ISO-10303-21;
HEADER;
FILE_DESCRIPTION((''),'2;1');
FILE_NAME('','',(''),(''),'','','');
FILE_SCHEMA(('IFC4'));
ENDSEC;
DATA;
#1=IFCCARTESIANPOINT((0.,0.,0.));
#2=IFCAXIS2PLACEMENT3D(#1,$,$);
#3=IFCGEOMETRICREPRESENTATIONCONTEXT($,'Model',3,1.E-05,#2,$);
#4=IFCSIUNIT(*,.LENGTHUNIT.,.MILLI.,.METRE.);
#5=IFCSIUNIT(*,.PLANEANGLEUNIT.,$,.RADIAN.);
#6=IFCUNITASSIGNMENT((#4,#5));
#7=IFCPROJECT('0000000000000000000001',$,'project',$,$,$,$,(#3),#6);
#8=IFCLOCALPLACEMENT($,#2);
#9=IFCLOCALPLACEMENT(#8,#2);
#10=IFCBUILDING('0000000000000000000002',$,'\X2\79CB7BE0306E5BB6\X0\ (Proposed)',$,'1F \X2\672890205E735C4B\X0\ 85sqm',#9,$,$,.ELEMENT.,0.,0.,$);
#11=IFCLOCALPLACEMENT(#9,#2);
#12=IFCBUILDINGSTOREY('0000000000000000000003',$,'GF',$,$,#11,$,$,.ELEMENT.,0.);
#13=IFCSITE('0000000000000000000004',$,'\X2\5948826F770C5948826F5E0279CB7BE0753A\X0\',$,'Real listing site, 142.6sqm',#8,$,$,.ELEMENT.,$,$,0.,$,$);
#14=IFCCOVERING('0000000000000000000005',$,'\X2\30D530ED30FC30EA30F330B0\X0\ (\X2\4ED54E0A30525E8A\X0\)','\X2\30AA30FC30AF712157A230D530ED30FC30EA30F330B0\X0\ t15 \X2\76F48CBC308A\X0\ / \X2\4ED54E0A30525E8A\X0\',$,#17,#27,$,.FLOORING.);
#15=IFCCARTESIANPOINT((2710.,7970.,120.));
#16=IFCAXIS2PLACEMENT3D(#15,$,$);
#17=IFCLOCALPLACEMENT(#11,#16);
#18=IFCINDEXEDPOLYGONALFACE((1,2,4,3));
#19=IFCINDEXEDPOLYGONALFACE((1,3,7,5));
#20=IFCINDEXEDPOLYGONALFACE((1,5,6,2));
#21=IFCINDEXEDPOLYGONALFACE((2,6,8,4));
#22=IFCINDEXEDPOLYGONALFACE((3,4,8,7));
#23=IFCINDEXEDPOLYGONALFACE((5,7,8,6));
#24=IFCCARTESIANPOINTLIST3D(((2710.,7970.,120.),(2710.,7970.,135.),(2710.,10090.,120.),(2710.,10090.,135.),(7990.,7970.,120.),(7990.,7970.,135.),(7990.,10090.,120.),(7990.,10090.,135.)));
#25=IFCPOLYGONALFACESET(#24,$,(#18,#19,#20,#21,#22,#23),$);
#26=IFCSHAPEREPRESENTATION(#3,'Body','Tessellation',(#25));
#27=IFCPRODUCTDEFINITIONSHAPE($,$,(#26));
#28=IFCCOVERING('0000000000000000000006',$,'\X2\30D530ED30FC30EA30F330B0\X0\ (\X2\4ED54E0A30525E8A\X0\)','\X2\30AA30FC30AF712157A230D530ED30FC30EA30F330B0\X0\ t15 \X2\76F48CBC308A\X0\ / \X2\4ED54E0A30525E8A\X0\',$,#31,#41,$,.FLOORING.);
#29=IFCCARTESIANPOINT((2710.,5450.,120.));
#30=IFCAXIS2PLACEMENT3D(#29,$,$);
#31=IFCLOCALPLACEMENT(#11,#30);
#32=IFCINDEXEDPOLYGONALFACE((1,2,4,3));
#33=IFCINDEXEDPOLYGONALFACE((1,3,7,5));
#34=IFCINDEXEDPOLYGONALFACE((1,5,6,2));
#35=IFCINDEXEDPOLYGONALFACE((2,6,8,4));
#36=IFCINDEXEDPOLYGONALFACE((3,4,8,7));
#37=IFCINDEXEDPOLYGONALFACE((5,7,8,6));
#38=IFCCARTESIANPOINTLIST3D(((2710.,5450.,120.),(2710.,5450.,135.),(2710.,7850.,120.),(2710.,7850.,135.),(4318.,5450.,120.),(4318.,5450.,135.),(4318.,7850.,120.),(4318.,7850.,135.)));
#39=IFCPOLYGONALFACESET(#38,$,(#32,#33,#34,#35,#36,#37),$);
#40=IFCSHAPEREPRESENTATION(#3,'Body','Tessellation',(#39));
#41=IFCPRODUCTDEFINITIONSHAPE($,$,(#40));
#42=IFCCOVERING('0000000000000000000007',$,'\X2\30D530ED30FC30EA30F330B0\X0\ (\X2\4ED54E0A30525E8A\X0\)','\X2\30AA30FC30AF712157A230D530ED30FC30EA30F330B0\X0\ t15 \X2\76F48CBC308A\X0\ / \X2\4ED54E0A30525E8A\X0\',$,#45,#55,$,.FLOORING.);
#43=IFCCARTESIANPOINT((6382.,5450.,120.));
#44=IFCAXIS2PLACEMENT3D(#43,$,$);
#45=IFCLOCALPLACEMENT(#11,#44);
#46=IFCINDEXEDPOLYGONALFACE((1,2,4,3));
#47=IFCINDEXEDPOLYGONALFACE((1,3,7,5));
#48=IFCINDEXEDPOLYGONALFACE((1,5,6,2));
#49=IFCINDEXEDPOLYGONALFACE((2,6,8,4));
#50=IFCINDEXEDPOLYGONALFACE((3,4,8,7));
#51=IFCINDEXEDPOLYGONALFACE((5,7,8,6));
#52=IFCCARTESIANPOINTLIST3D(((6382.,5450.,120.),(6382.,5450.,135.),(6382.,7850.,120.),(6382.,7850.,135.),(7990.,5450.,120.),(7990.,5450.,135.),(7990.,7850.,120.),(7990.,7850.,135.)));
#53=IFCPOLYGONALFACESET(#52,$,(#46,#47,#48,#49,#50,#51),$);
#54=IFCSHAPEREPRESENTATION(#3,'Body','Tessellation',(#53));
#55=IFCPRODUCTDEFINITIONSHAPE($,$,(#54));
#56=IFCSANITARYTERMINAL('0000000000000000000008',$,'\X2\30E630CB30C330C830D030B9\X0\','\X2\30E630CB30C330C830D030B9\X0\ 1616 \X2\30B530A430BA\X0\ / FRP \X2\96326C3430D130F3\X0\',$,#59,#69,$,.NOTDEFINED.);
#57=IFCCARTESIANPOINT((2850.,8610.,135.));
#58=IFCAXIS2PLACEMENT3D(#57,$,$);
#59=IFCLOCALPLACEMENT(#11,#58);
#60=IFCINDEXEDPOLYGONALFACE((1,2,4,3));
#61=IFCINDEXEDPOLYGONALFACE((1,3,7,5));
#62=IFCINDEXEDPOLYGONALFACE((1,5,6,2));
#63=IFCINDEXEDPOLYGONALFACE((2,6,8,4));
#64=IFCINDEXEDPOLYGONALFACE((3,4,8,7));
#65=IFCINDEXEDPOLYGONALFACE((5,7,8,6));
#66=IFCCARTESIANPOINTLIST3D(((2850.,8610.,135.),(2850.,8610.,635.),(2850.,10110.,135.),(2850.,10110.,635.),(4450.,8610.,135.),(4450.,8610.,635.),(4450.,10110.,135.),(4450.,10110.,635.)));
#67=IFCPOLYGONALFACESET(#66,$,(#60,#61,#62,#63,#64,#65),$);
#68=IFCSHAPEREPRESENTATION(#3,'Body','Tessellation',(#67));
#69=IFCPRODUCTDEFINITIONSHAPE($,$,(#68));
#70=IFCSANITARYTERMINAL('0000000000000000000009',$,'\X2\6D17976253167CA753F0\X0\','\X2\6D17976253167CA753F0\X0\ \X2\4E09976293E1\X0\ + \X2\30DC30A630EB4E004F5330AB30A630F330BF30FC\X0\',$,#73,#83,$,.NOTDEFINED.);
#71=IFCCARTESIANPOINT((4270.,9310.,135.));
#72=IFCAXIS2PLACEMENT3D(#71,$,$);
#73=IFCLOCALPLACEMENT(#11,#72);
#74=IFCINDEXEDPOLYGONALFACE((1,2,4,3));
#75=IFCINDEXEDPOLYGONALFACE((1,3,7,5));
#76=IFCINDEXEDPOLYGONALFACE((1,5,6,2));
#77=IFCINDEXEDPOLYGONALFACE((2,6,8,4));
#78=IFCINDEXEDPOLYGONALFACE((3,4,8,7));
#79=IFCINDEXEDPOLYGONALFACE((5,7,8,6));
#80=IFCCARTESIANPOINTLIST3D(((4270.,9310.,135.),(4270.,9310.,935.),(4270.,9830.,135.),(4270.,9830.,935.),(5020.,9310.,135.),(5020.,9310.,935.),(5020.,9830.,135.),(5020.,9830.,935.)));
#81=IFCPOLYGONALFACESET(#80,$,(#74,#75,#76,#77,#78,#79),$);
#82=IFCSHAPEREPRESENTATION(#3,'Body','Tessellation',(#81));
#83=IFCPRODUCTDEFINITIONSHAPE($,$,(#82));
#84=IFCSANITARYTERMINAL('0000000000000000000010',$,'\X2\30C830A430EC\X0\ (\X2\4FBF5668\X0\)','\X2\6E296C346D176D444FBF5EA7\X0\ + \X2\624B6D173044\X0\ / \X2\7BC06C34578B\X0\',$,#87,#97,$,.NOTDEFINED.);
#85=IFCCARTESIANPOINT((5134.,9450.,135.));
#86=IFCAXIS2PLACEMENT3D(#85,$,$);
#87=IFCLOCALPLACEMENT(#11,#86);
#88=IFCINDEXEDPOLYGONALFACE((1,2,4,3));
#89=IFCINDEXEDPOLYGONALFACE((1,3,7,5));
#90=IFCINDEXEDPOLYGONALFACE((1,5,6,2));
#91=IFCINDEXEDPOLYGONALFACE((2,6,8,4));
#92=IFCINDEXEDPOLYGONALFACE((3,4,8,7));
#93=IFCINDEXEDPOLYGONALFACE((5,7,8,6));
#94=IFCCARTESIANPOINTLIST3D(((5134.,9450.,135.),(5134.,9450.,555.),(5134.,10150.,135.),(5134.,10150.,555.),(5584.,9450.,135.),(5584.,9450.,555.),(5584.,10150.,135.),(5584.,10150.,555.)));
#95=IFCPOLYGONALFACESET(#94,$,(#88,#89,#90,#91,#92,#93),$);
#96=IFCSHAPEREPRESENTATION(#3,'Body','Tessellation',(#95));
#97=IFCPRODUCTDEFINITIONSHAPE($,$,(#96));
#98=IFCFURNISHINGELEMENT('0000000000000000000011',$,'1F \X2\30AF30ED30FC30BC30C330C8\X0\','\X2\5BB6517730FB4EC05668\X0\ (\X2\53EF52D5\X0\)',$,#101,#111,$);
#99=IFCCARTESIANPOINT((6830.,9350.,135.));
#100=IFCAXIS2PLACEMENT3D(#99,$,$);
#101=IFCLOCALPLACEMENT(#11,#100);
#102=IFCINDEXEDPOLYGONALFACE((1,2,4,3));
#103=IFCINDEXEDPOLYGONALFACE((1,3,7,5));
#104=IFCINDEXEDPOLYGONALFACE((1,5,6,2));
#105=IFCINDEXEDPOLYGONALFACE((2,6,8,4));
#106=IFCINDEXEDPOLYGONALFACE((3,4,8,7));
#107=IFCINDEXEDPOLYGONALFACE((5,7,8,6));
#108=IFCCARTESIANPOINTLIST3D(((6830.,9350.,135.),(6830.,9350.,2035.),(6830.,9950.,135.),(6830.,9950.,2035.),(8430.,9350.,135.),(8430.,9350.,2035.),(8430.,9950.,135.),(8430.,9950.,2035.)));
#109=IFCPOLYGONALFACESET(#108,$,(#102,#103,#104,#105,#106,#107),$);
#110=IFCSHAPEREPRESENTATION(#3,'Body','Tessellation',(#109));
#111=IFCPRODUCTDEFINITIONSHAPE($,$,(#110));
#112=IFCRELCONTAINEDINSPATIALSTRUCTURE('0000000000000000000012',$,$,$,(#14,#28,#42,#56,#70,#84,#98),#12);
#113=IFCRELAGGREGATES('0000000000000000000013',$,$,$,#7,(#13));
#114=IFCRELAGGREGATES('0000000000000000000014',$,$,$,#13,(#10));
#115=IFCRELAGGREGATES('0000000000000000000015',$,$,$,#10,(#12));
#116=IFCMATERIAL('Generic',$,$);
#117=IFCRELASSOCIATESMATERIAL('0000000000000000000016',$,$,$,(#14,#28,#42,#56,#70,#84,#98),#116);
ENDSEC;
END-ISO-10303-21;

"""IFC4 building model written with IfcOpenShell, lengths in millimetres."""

from ifc_helpers import new_model, si_unit, frame, frame_2d, origin, place, context, project, spatial, rectangle, extrude, material, element, save


model = new_model("IFC4")

# Units and contexts
model_context = context("Model", 3, precision=1e-05, world=origin())
ifc_project = project(units=[si_unit("LENGTHUNIT", "METRE", prefix="MILLI"), si_unit("PLANEANGLEUNIT", "RADIAN")], contexts=[model_context])

# Site, building, storey
site_placement = place(None, origin())
site = spatial("IfcSite", under=ifc_project, at=site_placement, Name="奈良県奈良市秋篠町", ObjectType="Real listing site, 142.6sqm", CompositionType="ELEMENT", RefElevation=0.0)
building_placement = place(site_placement, origin())
building = spatial("IfcBuilding", under=site, at=building_placement, Name="秋篠の家 (Proposed)", ObjectType="1F 木造平屋 85sqm", CompositionType="ELEMENT", ElevationOfRefHeight=0.0, ElevationOfTerrain=0.0)
storey_placement = place(building_placement, origin())
storey = spatial("IfcBuildingStorey", under=building, at=storey_placement, Name="GF", CompositionType="ELEMENT", Elevation=0.0)

# Coverings
ifc_material_1 = material(Name="Generic")
covering_1_placement = place(storey_placement, frame((2710.0, 7970.0, 120.0)))
element("IfcCovering", 1, at=covering_1_placement, inside=storey, material=ifc_material_1, Name="フローリング (仕上げ床)", Description="オーク無垢フローリング t15 直貼り / 仕上げ床", PredefinedType="FLOORING", context=model_context, shape_type="SweptSolid", body=[
    extrude(rectangle(XDim=5280.0, YDim=2120.0, at=frame_2d((2640.0, 1060.0))), frame((2710.0, 7970.0, 120.0)), (0.0, 0.0, 1.0), 15.0),
])
covering_2_placement = place(storey_placement, frame((2710.0, 5450.0, 120.0)))
element("IfcCovering", 2, at=covering_2_placement, inside=storey, material=ifc_material_1, Name="フローリング (仕上げ床)", Description="オーク無垢フローリング t15 直貼り / 仕上げ床", PredefinedType="FLOORING", context=model_context, shape_type="SweptSolid", body=[
    extrude(rectangle(XDim=1608.0, YDim=2400.0, at=frame_2d((804.0, 1200.0))), frame((2710.0, 5450.0, 120.0)), (0.0, 0.0, 1.0), 15.0),
])
covering_3_placement = place(storey_placement, frame((6382.0, 5450.0, 120.0)))
element("IfcCovering", 3, at=covering_3_placement, inside=storey, material=ifc_material_1, Name="フローリング (仕上げ床)", Description="オーク無垢フローリング t15 直貼り / 仕上げ床", PredefinedType="FLOORING", context=model_context, shape_type="SweptSolid", body=[
    extrude(rectangle(XDim=1608.0, YDim=2400.0, at=frame_2d((804.0, 1200.0))), frame((6382.0, 5450.0, 120.0)), (0.0, 0.0, 1.0), 15.0),
])

# Sanitary terminals
sanitary_terminal_1_placement = place(storey_placement, frame((2850.0, 8610.0, 135.0)))
element("IfcSanitaryTerminal", 4, at=sanitary_terminal_1_placement, inside=storey, material=ifc_material_1, Name="ユニットバス", Description="ユニットバス 1616 サイズ / FRP 防水パン", PredefinedType="NOTDEFINED", context=model_context, shape_type="SweptSolid", body=[
    extrude(rectangle(XDim=1600.0, YDim=1500.0, at=frame_2d((800.0, 750.0))), frame((2850.0, 8610.0, 135.0)), (0.0, 0.0, 1.0), 500.0),
])
sanitary_terminal_2_placement = place(storey_placement, frame((4270.0, 9310.0, 135.0)))
element("IfcSanitaryTerminal", 5, at=sanitary_terminal_2_placement, inside=storey, material=ifc_material_1, Name="洗面化粧台", Description="洗面化粧台 三面鏡 + ボウル一体カウンター", PredefinedType="NOTDEFINED", context=model_context, shape_type="SweptSolid", body=[
    extrude(rectangle(XDim=750.0, YDim=520.0, at=frame_2d((375.0, 260.0))), frame((4270.0, 9310.0, 135.0)), (0.0, 0.0, 1.0), 800.0),
])
sanitary_terminal_3_placement = place(storey_placement, frame((5134.0, 9450.0, 135.0)))
element("IfcSanitaryTerminal", 6, at=sanitary_terminal_3_placement, inside=storey, material=ifc_material_1, Name="トイレ (便器)", Description="温水洗浄便座 + 手洗い / 節水型", PredefinedType="NOTDEFINED", context=model_context, shape_type="SweptSolid", body=[
    extrude(rectangle(XDim=450.0, YDim=700.0, at=frame_2d((225.0, 350.0))), frame((5134.0, 9450.0, 135.0)), (0.0, 0.0, 1.0), 420.0),
])

# Furnishing element
furnishing_placement = place(storey_placement, frame((6830.0, 9350.0, 135.0)))
element("IfcFurnishingElement", 7, at=furnishing_placement, inside=storey, material=ifc_material_1, Name="1F クローゼット", Description="家具・什器 (可動)", context=model_context, shape_type="SweptSolid", body=[
    extrude(rectangle(XDim=1600.0, YDim=600.0, at=frame_2d((800.0, 300.0))), frame((6830.0, 9350.0, 135.0)), (0.0, 0.0, 1.0), 1900.0),
])

save(model, "model.ifc")
